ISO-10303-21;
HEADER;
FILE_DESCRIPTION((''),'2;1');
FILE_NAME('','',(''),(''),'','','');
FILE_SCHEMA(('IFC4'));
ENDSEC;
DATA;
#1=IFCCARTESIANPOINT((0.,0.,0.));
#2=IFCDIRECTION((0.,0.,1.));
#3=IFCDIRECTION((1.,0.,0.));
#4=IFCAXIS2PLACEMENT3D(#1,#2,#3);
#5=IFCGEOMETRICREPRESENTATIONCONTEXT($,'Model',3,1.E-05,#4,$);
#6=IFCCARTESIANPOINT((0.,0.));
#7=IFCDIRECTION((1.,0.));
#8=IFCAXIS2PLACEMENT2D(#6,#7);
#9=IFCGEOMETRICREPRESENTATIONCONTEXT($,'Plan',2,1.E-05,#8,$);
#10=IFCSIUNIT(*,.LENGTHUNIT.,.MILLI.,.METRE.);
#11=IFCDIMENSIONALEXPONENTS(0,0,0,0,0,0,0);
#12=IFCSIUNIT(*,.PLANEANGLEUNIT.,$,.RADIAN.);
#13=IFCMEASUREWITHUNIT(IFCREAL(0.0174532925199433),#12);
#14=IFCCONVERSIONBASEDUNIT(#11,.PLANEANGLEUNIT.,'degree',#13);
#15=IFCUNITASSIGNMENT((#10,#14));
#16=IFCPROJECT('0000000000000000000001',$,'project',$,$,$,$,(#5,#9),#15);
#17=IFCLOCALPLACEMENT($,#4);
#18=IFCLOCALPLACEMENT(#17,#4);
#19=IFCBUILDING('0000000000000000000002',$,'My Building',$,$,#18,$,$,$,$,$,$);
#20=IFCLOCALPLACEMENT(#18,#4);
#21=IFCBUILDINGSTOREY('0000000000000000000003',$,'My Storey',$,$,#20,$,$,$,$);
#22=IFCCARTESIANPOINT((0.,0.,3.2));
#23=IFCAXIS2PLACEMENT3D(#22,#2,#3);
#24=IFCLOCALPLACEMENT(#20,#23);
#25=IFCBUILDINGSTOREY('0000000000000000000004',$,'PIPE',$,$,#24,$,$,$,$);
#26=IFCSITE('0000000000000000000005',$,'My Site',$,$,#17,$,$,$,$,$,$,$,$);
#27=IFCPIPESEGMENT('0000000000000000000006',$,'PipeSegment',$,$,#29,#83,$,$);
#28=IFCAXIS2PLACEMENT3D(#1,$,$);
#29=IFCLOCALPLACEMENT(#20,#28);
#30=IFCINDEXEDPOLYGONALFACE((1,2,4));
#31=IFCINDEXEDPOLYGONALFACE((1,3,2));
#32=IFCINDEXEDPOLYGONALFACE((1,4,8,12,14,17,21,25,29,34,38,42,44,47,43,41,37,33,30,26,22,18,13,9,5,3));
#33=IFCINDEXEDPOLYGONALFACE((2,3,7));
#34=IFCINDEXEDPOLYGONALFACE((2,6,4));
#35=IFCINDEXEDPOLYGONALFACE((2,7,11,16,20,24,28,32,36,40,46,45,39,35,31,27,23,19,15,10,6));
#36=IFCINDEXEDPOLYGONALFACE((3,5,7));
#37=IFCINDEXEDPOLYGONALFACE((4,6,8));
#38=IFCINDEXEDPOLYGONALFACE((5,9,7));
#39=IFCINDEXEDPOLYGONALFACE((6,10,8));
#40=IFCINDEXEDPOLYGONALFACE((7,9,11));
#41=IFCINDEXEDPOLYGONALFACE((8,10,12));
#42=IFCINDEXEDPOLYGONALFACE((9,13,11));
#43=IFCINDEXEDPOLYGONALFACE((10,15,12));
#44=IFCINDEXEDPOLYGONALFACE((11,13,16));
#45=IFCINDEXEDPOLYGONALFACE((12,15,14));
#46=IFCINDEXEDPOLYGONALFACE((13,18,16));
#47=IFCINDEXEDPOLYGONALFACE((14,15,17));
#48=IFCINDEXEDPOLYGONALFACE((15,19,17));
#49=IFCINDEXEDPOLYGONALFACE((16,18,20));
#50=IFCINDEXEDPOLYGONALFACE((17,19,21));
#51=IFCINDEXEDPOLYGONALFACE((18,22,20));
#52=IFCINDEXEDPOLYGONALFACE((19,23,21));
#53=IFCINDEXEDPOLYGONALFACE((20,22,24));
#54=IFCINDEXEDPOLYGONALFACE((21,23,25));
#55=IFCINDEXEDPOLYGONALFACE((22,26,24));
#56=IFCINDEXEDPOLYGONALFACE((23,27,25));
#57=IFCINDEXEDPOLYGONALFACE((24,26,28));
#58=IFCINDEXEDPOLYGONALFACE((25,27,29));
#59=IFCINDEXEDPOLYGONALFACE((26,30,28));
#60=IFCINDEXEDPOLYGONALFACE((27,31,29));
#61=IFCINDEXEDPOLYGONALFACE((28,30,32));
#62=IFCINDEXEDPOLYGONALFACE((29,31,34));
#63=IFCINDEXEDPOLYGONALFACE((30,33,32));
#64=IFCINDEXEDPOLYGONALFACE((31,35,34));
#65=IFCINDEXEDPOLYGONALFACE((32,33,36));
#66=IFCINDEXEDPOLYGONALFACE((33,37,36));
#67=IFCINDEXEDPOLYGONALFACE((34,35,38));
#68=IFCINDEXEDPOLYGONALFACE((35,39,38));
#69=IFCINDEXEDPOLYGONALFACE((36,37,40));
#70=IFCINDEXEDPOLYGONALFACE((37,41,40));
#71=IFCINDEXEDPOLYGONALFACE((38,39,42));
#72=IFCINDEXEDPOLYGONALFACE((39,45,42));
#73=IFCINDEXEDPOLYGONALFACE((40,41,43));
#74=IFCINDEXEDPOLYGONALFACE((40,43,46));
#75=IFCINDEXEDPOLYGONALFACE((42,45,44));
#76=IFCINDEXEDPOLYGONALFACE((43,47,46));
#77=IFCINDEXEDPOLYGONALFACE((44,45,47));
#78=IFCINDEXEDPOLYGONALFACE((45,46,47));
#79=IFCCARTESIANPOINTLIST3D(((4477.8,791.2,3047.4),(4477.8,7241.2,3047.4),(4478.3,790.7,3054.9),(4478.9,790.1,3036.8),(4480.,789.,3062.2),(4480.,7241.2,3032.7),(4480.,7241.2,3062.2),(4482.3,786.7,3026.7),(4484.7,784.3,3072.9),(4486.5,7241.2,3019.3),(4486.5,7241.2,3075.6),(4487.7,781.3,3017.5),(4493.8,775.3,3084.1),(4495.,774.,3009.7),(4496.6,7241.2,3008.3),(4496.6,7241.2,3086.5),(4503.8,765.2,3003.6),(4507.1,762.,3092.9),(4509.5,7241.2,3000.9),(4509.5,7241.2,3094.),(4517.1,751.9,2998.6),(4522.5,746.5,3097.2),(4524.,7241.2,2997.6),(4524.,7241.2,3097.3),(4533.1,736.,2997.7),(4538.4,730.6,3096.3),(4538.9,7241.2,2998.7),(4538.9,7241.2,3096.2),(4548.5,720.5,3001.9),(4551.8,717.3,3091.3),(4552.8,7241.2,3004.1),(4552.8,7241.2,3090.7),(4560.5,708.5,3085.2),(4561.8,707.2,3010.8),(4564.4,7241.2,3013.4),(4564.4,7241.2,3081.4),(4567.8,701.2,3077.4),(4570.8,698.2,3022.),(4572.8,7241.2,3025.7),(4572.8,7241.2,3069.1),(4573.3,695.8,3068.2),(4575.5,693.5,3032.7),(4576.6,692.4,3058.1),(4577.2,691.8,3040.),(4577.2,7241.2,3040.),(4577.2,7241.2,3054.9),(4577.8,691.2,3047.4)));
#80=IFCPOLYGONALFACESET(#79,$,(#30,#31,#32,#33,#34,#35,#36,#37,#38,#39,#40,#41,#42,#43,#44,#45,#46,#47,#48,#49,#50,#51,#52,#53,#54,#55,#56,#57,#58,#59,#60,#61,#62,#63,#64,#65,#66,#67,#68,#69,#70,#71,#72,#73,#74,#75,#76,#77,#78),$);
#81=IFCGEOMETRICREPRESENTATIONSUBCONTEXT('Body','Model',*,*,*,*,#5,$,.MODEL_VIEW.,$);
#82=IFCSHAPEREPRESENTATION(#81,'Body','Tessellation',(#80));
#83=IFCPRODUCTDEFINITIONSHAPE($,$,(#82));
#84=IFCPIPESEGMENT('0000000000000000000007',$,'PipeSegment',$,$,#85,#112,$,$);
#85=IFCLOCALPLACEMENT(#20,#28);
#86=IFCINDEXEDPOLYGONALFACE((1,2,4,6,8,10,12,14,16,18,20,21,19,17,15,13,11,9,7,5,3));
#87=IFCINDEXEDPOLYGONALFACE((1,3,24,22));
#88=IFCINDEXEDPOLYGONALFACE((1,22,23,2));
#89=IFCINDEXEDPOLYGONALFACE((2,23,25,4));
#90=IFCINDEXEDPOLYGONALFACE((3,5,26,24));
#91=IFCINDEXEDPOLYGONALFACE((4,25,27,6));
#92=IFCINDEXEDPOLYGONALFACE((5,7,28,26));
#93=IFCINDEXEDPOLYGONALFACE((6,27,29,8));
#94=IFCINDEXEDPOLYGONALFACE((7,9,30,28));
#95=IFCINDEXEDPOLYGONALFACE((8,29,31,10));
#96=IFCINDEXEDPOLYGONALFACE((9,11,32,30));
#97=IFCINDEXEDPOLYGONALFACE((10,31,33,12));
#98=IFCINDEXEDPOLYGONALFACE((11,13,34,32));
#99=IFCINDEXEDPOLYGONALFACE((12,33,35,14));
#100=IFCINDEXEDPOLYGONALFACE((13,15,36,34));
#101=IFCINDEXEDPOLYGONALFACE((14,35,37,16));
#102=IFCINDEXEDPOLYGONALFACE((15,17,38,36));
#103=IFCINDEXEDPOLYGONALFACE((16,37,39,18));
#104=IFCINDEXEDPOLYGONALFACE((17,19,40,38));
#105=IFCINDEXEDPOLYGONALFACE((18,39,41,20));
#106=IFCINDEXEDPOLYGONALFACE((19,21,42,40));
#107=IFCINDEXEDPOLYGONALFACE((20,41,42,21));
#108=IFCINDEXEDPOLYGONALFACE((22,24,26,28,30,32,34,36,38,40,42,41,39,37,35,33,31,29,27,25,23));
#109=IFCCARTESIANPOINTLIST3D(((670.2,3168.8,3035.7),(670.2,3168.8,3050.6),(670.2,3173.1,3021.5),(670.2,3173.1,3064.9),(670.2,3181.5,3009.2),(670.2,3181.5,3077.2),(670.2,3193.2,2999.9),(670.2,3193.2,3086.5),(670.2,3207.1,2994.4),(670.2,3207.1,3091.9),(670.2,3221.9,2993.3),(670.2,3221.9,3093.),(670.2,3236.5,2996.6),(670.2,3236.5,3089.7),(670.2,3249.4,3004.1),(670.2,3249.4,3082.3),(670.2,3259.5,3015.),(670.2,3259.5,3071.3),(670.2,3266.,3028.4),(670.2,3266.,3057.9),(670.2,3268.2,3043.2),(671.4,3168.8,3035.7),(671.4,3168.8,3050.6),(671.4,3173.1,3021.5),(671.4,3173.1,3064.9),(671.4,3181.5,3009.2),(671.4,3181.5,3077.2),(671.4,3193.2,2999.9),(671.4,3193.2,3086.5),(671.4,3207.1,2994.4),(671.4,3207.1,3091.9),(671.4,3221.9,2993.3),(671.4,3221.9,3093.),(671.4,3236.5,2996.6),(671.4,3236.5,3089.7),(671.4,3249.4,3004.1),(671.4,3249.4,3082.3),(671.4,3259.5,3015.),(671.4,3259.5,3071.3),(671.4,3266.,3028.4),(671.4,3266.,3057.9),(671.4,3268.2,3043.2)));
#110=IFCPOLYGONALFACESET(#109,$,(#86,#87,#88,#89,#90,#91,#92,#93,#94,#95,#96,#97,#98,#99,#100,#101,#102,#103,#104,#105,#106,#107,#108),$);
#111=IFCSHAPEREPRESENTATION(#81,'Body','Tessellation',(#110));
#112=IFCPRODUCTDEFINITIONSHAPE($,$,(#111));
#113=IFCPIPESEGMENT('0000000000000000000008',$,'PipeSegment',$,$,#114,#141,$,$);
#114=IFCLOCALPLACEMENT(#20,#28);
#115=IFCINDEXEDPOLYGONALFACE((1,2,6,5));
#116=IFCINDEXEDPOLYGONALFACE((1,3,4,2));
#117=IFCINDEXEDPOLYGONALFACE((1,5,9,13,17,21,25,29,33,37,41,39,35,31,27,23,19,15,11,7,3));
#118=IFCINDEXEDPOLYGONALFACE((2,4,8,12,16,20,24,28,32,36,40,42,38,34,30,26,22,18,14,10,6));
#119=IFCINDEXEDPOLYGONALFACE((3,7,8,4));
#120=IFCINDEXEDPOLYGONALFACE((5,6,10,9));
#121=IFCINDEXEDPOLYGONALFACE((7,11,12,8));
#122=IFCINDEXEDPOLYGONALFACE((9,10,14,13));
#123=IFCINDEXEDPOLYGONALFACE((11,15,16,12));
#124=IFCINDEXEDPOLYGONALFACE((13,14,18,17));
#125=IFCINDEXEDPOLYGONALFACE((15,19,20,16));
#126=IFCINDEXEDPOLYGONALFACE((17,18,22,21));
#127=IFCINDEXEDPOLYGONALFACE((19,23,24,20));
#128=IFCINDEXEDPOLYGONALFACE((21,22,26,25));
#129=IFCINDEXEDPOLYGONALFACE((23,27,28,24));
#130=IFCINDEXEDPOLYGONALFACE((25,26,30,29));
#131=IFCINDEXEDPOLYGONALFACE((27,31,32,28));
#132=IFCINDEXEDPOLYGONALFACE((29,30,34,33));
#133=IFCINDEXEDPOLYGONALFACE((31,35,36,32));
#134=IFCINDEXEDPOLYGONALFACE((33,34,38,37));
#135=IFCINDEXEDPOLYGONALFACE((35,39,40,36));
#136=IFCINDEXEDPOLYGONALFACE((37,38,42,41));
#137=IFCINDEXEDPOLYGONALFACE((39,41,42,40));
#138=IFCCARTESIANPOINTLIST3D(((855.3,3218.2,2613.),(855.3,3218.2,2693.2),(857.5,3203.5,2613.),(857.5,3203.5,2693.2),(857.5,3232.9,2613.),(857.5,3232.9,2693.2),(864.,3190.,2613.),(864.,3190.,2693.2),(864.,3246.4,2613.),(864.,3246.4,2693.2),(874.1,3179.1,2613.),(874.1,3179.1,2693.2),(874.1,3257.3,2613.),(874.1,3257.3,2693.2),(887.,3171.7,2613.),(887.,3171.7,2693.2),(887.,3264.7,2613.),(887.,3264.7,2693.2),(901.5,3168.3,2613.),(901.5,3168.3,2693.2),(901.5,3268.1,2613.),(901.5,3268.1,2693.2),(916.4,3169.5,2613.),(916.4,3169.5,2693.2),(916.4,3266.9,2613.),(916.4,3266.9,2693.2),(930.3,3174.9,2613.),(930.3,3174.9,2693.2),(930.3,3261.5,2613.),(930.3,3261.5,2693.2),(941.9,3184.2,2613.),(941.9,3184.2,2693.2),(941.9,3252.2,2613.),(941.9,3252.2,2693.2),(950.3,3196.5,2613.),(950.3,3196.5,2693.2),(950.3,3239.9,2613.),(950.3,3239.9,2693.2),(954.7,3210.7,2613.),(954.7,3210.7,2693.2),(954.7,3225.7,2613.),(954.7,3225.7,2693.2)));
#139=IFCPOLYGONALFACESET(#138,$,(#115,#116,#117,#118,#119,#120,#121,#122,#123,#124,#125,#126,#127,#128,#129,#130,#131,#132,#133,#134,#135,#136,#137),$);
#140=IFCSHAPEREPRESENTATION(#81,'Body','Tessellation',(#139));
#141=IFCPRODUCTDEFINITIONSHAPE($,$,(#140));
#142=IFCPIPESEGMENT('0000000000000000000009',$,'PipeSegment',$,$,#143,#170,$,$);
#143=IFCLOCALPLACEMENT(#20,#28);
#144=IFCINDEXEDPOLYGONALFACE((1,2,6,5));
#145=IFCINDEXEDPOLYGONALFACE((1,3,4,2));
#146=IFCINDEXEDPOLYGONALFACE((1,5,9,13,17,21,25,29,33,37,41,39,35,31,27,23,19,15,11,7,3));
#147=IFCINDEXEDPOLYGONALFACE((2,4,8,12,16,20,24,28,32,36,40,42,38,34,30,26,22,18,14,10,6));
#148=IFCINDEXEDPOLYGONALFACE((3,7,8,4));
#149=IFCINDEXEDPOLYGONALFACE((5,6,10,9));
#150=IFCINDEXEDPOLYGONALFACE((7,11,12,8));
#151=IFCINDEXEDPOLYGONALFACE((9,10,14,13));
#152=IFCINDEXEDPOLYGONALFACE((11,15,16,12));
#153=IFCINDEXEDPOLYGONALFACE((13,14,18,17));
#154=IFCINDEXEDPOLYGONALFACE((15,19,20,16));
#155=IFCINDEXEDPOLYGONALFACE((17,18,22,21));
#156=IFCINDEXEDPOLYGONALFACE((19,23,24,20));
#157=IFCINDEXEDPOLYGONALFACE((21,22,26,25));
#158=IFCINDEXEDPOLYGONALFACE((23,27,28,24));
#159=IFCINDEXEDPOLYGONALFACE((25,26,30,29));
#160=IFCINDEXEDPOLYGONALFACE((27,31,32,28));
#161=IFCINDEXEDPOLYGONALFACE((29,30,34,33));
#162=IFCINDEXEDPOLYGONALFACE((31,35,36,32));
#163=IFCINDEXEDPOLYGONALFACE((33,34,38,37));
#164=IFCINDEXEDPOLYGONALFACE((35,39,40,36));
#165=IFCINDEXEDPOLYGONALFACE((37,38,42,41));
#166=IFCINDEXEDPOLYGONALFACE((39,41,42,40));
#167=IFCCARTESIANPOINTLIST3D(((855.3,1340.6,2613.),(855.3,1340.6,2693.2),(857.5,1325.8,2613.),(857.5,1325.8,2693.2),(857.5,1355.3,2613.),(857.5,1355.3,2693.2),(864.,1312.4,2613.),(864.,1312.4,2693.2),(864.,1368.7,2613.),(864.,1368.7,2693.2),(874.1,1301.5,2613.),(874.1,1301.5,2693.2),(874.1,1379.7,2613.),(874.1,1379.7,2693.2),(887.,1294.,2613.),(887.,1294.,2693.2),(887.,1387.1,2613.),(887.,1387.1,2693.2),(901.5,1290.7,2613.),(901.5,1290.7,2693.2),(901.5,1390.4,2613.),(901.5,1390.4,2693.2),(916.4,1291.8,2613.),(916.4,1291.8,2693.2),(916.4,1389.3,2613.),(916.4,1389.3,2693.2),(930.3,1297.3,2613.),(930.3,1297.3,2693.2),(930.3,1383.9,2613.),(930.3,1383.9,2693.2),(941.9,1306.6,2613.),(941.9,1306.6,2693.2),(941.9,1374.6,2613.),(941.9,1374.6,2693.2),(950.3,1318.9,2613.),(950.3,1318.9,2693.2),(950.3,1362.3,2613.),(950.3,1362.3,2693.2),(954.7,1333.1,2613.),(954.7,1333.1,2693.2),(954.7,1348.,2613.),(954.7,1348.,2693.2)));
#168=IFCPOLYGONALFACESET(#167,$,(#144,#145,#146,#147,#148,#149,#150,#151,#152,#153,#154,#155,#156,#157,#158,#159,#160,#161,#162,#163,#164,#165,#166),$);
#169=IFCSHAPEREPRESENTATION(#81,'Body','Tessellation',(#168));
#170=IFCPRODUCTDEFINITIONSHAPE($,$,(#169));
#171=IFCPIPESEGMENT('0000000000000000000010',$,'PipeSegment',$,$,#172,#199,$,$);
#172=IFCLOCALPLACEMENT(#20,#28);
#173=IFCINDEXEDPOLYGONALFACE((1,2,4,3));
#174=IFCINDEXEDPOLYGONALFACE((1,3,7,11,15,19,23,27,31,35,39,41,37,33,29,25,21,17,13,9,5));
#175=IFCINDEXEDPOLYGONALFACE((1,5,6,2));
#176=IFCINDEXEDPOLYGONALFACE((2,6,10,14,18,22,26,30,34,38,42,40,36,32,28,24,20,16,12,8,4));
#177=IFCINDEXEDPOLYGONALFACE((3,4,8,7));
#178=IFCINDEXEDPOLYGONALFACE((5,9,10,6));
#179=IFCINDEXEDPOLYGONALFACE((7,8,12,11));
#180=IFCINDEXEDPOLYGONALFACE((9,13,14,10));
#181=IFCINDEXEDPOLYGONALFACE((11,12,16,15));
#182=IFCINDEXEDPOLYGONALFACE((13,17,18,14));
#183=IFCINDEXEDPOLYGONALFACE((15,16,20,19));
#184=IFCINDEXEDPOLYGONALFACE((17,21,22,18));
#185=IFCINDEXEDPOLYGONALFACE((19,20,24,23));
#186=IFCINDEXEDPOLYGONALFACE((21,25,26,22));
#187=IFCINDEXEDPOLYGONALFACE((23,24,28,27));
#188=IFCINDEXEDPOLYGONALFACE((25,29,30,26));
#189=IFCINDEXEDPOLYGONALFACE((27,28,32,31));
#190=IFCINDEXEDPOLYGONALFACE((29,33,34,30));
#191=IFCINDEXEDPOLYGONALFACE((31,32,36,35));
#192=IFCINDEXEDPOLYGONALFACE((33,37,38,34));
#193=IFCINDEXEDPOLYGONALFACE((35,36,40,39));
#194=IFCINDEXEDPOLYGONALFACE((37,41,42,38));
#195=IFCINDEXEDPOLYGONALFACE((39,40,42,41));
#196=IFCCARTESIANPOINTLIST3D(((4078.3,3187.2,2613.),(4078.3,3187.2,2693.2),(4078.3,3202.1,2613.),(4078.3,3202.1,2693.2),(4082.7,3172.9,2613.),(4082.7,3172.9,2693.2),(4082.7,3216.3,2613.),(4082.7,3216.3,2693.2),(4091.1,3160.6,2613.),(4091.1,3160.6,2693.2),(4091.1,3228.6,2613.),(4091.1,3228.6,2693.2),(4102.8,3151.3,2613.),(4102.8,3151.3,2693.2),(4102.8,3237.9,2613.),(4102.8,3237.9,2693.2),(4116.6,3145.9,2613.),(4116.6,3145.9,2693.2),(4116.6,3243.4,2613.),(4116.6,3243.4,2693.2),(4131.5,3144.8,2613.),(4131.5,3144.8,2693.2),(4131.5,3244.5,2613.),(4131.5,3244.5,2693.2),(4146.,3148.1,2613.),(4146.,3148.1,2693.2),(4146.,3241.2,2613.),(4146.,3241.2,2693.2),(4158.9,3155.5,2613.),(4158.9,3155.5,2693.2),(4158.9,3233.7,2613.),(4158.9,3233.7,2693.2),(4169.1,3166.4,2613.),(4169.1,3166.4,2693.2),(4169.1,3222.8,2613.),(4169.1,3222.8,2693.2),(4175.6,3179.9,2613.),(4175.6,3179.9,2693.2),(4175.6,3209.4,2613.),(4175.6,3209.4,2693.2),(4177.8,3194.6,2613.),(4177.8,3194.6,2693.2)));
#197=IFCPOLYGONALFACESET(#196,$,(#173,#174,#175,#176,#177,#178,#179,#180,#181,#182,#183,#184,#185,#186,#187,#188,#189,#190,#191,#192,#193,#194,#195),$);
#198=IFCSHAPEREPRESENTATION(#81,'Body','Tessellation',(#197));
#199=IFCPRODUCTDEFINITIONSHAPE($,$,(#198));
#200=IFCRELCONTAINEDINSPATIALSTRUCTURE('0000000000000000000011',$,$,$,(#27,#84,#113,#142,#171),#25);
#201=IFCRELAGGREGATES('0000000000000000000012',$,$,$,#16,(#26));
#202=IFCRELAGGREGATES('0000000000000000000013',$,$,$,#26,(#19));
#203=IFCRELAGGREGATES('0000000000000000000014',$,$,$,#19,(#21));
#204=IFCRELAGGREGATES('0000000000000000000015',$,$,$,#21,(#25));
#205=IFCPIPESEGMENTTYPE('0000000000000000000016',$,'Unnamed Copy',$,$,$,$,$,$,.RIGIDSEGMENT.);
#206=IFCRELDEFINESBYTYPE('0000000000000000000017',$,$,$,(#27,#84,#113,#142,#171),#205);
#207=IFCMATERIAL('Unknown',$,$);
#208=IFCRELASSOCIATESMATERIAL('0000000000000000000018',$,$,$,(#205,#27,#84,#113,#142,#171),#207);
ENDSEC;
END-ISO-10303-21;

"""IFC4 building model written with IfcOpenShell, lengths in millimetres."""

from ifc_helpers import new_model, entity, si_unit, converted_unit, frame, origin_with_axes, origin_2d_with_axis, place, context, subcontext, project, spatial, circle, extrude, clip, halfspace, material, material_profile, profile_set, profile_usage, type_object, element, save


model = new_model("IFC4")

# Units and contexts
model_context = context("Model", 3, precision=1e-05, world=origin_with_axes())
plan_context = context("Plan", 2, precision=1e-05, world=origin_2d_with_axis())
body_context = subcontext(model_context, "Body", "Model", "MODEL_VIEW")
ifc_project = project(units=[si_unit("LENGTHUNIT", "METRE", prefix="MILLI"), converted_unit("PLANEANGLEUNIT", "degree", entity("IfcReal", 0.0174532925199433), si_unit("PLANEANGLEUNIT", "RADIAN"), dimensions=[0, 0, 0, 0, 0, 0, 0])], contexts=[model_context, plan_context])

# Site, building, storeys
site_placement = place(None, origin_with_axes())
site = spatial("IfcSite", under=ifc_project, at=site_placement, Name="My Site")
building_placement = place(site_placement, origin_with_axes())
building = spatial("IfcBuilding", under=site, at=building_placement, Name="My Building")
storey_1_placement = place(building_placement, origin_with_axes())
storey_1 = spatial("IfcBuildingStorey", under=building, at=storey_1_placement, Name="My Storey")
storey_2_placement = place(storey_1_placement, frame((0.0, 0.0, 3.2), z_axis=(0.0, 0.0, 1.0), x_axis=(1.0, 0.0, 0.0)))
storey_2 = spatial("IfcBuildingStorey", under=storey_1, at=storey_2_placement, Name="PIPE")

# Pipe segments
ifc_material = material(Name="Unknown")
ifc_material_profile_1 = material_profile(ifc_material, circle(Radius=50.0))
ifc_profile_set_1 = profile_set([ifc_material_profile_1])
pipe_segment_type = type_object("IfcPipeSegmentType", Name="Unnamed Copy", PredefinedType="RIGIDSEGMENT", material=ifc_profile_set_1)
ifc_profile_usage_1 = profile_usage(ifc_profile_set_1, cardinal=10)
pipe_segment_1_placement = place(storey_2_placement, frame((4527.8, 691.2, 3044.2), z_axis=(0.0, 1.0, 0.0), x_axis=(-1.0, 0.0, 0.0)))
element("IfcPipeSegment", 1, at=pipe_segment_1_placement, inside=storey_2, type_object=pipe_segment_type, material=ifc_profile_usage_1, Name="PipeSegment", context=body_context, shape_type="Clipping", body=[
    clip(extrude(circle(Radius=50.0), origin_with_axes(), (0.0, 0.0, 1.0), 6550.0), halfspace(frame((-50.0, -3000.0, 0.0), z_axis=(0.707105, 0.0, -0.707108), x_axis=(0.0, -1.0, 0.0)), False)),
])
ifc_profile_usage_2 = profile_usage(ifc_profile_set_1, cardinal=10)
pipe_segment_2_placement = place(storey_2_placement, frame((670.2, 3218.2, 3040.0), z_axis=(1.0, 0.0, 0.0), x_axis=(0.0, 1.0, 0.0)))
element("IfcPipeSegment", 2, at=pipe_segment_2_placement, inside=storey_2, type_object=pipe_segment_type, material=ifc_profile_usage_2, Name="PipeSegment", context=body_context, shape_type="SweptSolid", body=[
    extrude(circle(Radius=50.0), origin_with_axes(), (0.0, 0.0, 1.0), 1.2),
])
ifc_profile_usage_3 = profile_usage(ifc_profile_set_1, cardinal=10)
pipe_segment_3_placement = place(storey_2_placement, frame((905.3, 3218.2, 2690.0), z_axis=(0.0, 0.0, -1.0), x_axis=(-1.0, 0.0, 0.0)))
element("IfcPipeSegment", 3, at=pipe_segment_3_placement, inside=storey_2, type_object=pipe_segment_type, material=ifc_profile_usage_3, Name="PipeSegment", context=body_context, shape_type="SweptSolid", body=[
    extrude(circle(Radius=50.0), origin_with_axes(), (0.0, 0.0, 1.0), 80.1),
])
ifc_profile_usage_4 = profile_usage(ifc_profile_set_1, cardinal=10)
pipe_segment_4_placement = place(storey_2_placement, frame((905.3, 1340.6, 2690.0), z_axis=(0.0, 0.0, -1.0), x_axis=(-1.0, 0.0, 0.0)))
element("IfcPipeSegment", 4, at=pipe_segment_4_placement, inside=storey_2, type_object=pipe_segment_type, material=ifc_profile_usage_4, Name="PipeSegment", context=body_context, shape_type="SweptSolid", body=[
    extrude(circle(Radius=50.0), origin_with_axes(), (0.0, 0.0, 1.0), 80.1),
])
ifc_profile_usage_5 = profile_usage(ifc_profile_set_1, cardinal=10)
pipe_segment_5_placement = place(storey_2_placement, frame((4127.8, 3194.6, 2690.0), z_axis=(0.0, 0.0, -1.0), x_axis=(1.0, 0.0, 0.0)))
element("IfcPipeSegment", 5, at=pipe_segment_5_placement, inside=storey_2, type_object=pipe_segment_type, material=ifc_profile_usage_5, Name="PipeSegment", context=body_context, shape_type="SweptSolid", body=[
    extrude(circle(Radius=50.0), origin_with_axes(), (0.0, 0.0, 1.0), 80.1),
])

save(model, "model.ifc")
